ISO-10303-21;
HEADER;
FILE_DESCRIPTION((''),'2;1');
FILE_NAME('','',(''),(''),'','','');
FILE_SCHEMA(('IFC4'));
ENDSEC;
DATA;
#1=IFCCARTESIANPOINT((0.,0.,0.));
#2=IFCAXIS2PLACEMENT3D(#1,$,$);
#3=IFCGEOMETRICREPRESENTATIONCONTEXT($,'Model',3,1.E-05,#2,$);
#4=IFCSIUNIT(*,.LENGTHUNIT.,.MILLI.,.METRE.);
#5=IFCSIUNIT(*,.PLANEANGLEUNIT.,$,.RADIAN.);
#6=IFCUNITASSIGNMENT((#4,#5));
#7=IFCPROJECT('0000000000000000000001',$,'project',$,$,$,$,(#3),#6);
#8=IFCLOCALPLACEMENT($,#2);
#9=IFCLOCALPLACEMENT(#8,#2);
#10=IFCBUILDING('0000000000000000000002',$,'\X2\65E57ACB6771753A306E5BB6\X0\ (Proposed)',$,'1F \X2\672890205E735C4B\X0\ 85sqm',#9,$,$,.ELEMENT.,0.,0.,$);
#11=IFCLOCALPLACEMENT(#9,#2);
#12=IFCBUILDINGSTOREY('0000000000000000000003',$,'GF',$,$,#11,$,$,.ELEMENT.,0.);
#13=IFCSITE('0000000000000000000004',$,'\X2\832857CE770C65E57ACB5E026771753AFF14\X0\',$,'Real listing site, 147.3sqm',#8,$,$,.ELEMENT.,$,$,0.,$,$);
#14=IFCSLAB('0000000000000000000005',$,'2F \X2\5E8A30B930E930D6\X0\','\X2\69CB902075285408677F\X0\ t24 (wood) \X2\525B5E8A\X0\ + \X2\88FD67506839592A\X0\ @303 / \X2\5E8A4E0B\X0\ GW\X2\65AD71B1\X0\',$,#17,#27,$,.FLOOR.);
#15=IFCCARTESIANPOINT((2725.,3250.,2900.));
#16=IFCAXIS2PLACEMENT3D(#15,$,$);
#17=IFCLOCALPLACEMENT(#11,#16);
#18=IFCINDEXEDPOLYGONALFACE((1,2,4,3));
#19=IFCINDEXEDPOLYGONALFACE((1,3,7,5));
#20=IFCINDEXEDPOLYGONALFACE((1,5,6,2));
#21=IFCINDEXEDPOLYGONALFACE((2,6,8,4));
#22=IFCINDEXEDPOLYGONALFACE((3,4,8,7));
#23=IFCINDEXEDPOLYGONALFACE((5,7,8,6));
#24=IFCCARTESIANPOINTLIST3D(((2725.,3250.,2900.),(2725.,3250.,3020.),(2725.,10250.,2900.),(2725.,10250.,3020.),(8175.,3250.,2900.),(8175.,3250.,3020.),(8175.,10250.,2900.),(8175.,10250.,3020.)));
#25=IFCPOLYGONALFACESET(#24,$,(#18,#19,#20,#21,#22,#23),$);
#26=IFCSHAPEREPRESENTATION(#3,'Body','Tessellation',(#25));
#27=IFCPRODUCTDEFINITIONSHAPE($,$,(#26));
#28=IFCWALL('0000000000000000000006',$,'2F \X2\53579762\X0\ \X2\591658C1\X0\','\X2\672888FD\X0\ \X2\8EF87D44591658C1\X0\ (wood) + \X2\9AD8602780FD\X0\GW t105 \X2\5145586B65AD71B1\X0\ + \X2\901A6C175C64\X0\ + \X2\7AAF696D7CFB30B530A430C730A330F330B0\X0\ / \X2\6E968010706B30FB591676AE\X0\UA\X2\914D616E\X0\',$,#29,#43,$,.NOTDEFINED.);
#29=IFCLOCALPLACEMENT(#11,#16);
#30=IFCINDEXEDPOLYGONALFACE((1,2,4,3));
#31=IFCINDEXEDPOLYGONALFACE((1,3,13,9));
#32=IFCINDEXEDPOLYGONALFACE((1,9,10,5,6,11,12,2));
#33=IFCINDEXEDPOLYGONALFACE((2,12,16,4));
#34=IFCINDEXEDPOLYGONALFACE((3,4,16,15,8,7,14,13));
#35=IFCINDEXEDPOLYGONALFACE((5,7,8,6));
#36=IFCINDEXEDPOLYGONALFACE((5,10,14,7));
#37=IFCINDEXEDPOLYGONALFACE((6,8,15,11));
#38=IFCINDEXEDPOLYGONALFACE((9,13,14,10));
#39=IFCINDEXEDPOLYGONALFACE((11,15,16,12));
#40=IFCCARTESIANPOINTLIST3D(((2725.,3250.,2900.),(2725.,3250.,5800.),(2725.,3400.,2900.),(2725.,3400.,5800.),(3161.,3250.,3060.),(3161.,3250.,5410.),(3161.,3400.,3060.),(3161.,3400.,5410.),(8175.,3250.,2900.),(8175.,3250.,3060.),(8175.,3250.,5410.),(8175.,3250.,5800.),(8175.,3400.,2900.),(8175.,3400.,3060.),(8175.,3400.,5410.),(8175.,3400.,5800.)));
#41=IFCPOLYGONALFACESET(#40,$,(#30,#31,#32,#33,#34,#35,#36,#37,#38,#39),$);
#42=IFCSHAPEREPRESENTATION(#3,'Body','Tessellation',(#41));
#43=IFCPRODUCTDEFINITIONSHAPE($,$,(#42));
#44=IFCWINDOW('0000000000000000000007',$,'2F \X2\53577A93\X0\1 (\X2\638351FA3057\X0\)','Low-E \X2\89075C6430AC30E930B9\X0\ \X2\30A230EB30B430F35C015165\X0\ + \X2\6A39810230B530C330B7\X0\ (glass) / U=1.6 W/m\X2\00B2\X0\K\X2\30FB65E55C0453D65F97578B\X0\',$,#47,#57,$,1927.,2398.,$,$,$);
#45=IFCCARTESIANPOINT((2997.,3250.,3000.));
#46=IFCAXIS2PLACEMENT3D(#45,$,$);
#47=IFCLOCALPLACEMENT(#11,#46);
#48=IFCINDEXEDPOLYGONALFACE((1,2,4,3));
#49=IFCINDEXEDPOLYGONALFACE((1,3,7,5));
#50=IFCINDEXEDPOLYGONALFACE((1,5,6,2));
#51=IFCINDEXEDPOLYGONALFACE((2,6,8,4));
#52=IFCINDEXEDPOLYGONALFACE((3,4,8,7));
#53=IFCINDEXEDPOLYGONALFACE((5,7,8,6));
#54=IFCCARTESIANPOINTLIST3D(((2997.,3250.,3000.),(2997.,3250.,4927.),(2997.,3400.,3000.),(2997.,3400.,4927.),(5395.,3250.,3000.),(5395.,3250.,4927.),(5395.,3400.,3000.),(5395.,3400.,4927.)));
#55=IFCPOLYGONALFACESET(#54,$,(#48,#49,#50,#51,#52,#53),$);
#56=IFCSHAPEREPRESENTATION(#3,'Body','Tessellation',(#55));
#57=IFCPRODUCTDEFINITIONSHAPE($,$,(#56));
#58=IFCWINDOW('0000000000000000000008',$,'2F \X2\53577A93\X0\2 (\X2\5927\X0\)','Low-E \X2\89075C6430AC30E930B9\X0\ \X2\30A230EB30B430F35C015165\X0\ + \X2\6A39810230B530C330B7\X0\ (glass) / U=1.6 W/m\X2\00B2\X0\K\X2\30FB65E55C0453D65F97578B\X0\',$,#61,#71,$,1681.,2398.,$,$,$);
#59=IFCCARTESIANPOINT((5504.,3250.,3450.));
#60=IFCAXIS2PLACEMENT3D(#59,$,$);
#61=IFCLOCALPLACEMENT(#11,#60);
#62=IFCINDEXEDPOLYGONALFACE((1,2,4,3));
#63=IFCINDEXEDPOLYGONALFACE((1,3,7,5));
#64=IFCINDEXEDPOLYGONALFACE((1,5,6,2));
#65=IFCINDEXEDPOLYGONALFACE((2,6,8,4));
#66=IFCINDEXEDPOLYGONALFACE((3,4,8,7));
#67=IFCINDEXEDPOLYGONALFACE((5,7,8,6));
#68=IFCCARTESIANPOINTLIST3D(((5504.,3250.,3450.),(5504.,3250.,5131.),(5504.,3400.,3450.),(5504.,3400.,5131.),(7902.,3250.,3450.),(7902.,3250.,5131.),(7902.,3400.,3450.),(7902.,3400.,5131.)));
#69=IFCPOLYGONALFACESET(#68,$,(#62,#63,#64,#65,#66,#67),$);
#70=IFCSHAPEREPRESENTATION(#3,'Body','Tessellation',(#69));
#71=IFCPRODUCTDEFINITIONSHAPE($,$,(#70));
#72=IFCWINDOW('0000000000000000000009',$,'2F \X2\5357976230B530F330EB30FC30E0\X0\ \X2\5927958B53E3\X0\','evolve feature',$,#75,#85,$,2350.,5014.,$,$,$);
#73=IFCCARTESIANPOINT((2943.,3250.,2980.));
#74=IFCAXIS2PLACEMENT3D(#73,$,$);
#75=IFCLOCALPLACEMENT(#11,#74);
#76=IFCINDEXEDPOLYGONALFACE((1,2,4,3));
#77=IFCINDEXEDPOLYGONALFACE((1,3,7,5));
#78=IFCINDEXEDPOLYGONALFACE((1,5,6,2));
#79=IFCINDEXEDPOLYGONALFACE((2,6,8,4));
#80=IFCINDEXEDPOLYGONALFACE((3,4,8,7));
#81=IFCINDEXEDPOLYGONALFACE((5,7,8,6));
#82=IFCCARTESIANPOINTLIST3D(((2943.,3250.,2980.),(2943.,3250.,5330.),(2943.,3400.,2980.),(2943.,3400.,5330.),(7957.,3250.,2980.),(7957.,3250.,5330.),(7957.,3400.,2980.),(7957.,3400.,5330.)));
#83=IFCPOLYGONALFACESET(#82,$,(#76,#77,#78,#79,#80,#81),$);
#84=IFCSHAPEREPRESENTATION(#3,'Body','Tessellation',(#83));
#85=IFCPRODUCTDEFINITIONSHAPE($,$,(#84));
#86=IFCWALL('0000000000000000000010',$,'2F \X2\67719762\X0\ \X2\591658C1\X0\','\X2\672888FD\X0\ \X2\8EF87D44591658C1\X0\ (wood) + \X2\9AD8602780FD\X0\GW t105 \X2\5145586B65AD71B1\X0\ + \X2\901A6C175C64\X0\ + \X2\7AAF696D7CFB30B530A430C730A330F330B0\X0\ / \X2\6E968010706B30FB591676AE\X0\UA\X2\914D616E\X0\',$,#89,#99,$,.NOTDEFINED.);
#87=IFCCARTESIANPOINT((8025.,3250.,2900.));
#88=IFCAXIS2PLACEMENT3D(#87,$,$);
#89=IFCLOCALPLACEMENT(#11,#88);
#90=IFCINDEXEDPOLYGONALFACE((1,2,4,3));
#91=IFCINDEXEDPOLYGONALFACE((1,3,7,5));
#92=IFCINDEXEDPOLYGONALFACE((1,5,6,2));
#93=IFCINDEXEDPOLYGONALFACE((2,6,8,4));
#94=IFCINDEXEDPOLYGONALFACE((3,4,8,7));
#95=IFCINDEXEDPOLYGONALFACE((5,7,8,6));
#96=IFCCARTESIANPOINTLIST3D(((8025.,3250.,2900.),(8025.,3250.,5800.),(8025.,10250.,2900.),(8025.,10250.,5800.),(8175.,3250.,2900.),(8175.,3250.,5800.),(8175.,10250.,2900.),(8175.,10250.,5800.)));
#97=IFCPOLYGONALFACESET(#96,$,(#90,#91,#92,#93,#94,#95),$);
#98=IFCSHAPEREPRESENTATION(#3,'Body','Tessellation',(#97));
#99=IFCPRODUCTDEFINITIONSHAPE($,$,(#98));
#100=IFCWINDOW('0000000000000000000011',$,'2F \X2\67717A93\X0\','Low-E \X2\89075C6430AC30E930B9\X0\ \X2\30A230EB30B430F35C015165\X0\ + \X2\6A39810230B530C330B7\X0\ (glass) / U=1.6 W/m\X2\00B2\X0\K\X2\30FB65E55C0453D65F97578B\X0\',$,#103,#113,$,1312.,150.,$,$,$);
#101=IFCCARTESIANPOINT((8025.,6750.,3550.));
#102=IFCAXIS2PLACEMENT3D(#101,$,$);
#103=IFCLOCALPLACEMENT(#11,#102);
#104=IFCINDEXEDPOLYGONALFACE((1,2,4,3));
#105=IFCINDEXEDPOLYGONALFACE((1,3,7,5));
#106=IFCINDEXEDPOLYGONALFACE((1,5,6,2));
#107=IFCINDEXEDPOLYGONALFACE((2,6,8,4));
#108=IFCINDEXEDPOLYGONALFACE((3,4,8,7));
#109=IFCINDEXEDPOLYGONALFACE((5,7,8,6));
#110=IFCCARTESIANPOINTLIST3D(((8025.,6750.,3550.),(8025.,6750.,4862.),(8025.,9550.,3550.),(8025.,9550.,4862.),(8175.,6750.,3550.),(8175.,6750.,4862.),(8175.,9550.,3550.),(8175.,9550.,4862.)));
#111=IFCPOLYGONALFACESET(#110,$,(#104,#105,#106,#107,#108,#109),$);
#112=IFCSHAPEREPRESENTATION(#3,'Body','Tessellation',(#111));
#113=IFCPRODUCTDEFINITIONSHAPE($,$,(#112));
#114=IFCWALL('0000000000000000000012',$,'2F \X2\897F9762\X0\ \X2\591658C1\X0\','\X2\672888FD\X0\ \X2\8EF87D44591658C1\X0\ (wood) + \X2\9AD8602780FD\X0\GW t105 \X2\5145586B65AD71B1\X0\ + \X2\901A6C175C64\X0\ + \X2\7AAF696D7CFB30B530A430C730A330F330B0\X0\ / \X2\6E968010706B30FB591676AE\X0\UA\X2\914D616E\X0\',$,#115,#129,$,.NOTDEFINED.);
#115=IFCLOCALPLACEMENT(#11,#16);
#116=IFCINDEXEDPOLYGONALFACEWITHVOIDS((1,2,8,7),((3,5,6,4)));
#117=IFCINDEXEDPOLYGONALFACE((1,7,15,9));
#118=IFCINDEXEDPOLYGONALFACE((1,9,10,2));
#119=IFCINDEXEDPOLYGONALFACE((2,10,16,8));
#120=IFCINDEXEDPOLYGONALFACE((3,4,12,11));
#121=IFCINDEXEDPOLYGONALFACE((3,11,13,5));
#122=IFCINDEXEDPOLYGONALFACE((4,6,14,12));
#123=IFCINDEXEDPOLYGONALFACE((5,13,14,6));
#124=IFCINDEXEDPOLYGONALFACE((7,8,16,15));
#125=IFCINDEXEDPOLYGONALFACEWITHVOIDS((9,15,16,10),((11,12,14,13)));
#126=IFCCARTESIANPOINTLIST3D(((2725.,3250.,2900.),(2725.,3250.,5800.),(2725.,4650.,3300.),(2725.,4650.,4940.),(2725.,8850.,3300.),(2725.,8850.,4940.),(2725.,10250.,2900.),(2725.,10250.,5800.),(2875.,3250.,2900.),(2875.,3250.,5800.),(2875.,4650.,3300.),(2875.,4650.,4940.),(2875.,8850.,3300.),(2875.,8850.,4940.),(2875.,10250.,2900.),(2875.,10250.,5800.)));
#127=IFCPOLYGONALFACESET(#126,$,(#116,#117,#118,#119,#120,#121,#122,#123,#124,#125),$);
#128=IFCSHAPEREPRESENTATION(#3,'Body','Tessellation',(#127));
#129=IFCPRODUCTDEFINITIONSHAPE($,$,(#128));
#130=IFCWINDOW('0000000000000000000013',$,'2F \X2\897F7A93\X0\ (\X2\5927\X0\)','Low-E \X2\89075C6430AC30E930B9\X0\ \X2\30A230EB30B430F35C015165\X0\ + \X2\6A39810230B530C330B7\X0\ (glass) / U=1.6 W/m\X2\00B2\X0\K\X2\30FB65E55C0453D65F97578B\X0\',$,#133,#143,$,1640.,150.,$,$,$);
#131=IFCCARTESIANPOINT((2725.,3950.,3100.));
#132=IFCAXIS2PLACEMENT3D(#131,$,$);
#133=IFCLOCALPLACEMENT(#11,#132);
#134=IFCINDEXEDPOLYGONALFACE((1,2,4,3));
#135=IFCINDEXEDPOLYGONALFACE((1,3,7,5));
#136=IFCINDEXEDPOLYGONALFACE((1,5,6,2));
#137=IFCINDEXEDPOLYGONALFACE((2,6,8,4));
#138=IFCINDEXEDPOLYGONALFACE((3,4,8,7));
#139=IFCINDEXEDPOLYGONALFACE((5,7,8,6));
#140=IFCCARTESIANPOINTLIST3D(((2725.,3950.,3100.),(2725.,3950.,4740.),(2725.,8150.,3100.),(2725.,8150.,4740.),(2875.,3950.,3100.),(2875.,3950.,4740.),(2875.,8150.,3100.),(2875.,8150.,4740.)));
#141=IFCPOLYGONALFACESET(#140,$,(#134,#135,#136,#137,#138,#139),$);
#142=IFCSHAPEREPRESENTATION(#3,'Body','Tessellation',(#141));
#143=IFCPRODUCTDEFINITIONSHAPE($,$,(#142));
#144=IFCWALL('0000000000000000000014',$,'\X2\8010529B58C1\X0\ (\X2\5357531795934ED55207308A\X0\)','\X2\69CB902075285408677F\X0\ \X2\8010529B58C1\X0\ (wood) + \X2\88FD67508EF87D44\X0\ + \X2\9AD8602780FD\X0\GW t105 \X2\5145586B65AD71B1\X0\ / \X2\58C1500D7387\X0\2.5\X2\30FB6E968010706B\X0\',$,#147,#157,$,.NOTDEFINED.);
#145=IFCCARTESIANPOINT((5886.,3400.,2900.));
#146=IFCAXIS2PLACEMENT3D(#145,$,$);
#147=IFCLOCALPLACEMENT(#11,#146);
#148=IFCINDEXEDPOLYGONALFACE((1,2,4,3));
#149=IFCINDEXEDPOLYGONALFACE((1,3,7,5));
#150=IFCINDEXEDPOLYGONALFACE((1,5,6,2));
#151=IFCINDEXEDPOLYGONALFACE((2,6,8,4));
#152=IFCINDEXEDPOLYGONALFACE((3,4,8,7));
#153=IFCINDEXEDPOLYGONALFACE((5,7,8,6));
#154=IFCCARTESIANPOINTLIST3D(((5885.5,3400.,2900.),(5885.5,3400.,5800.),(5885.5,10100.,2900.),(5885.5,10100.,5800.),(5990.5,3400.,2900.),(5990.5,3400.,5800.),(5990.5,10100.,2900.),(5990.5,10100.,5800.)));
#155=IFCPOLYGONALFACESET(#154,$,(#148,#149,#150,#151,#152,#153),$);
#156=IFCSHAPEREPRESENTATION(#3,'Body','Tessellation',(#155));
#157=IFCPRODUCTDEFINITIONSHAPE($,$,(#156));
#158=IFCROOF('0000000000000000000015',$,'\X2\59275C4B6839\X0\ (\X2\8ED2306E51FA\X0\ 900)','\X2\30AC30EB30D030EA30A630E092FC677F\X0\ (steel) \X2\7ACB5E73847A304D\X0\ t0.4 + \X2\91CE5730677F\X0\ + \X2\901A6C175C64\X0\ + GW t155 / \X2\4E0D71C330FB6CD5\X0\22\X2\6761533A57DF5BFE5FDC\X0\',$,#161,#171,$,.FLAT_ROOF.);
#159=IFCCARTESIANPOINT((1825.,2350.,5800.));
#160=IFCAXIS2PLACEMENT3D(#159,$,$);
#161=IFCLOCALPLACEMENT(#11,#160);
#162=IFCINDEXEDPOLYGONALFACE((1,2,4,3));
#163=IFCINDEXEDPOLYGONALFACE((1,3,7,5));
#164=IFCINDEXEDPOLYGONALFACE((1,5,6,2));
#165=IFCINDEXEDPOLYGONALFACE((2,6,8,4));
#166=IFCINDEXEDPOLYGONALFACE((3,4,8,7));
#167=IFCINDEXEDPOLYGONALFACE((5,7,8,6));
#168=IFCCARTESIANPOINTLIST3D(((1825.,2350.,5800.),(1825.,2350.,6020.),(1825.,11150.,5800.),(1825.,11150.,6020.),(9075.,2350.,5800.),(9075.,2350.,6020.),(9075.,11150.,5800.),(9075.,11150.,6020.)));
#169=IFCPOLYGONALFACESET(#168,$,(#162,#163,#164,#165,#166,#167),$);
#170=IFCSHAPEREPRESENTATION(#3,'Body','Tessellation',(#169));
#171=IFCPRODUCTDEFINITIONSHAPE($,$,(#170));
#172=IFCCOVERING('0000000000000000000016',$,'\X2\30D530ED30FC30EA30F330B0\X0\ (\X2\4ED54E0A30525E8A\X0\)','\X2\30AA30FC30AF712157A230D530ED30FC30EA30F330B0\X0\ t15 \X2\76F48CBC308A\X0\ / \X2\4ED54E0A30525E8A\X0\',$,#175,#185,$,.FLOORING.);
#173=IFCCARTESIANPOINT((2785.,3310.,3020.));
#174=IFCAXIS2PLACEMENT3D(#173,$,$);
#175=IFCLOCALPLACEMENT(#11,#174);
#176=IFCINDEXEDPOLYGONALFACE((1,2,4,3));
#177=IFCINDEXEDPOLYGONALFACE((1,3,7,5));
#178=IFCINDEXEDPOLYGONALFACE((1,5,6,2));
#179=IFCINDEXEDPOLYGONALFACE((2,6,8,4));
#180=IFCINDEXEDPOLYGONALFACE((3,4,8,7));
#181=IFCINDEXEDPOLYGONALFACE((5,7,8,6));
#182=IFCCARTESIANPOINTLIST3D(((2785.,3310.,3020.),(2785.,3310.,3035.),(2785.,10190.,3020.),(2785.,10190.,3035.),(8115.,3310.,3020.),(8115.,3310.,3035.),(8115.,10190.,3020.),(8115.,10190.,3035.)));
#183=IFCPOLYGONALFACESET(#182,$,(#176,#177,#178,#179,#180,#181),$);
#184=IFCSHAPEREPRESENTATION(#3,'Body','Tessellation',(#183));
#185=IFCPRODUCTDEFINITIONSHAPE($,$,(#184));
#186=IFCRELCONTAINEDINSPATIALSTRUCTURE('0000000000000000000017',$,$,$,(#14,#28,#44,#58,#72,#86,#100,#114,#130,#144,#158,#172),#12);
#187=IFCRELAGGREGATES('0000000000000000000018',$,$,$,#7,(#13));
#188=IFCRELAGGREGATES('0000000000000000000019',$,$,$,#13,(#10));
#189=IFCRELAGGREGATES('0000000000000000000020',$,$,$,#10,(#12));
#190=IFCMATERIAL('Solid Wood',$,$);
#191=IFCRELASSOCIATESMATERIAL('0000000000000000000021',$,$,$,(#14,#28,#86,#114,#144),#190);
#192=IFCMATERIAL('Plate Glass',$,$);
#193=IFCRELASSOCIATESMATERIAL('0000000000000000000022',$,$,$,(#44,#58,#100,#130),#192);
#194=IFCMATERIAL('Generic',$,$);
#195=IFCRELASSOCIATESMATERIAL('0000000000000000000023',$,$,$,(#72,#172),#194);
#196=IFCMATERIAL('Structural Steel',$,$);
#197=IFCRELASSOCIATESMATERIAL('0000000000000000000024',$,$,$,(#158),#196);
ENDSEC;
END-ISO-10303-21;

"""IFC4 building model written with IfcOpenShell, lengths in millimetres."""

from ifc_helpers import new_model, si_unit, frame, frame_2d, origin, place, context, project, spatial, rectangle, extrude, material, element, fill, save


model = new_model("IFC4")

# Units and contexts
model_context = context("Model", 3, precision=1e-05, world=origin())
ifc_project = project(units=[si_unit("LENGTHUNIT", "METRE", prefix="MILLI"), si_unit("PLANEANGLEUNIT", "RADIAN")], contexts=[model_context])

# Site, building, storey
site_placement = place(None, origin())
site = spatial("IfcSite", under=ifc_project, at=site_placement, Name="茨城県日立市東町４", ObjectType="Real listing site, 147.3sqm", CompositionType="ELEMENT", RefElevation=0.0)
building_placement = place(site_placement, origin())
building = spatial("IfcBuilding", under=site, at=building_placement, Name="日立東町の家 (Proposed)", ObjectType="1F 木造平屋 85sqm", CompositionType="ELEMENT", ElevationOfRefHeight=0.0, ElevationOfTerrain=0.0)
storey_placement = place(building_placement, origin())
storey = spatial("IfcBuildingStorey", under=building, at=storey_placement, Name="GF", CompositionType="ELEMENT", Elevation=0.0)

# Slab
ifc_material_1 = material(Name="Solid Wood")
slab_placement = place(storey_placement, frame((2725.0, 3250.0, 2900.0)))
element("IfcSlab", 1, at=slab_placement, inside=storey, material=ifc_material_1, Name="2F 床スラブ", Description="構造用合板 t24 (wood) 剛床 + 製材根太 @303 / 床下 GW断熱", PredefinedType="FLOOR", context=model_context, shape_type="SweptSolid", body=[
    extrude(rectangle(XDim=5450.0, YDim=7000.0, at=frame_2d((2725.0, 3500.0))), frame((2725.0, 3250.0, 2900.0)), (0.0, 0.0, 1.0), 120.0),
])

# Wall, openings, windows
wall_1_placement = place(storey_placement, frame((2725.0, 3250.0, 2900.0)))
wall_1 = element("IfcWall", 2, at=wall_1_placement, inside=storey, material=ifc_material_1, Name="2F 南面 外壁", Description="木製 軸組外壁 (wood) + 高性能GW t105 充填断熱 + 通気層 + 窯業系サイディング / 準耐火・外皮UA配慮", PredefinedType="NOTDEFINED", context=model_context, shape_type="SweptSolid", body=[
    extrude(rectangle(XDim=5450.0, YDim=150.0, at=frame_2d((2725.0, 75.0))), frame((2725.0, 3250.0, 2900.0)), (0.0, 0.0, 1.0), 2900.0),
])
opening_1_placement = place(storey_placement, frame((2997.0, 3250.0, 3000.0)))
opening_1 = element("IfcOpeningElement", 3, at=opening_1_placement, cuts=wall_1, PredefinedType="NOTDEFINED", context=model_context, shape_type="SweptSolid", body=[
    extrude(rectangle(XDim=2398.0, YDim=150.0, at=frame_2d((1199.0, 75.0))), frame((2997.0, 3250.0, 3000.0)), (0.0, 0.0, 1.0), 1927.0),
])
opening_2_placement = place(storey_placement, frame((5504.0, 3250.0, 3450.0)))
opening_2 = element("IfcOpeningElement", 4, at=opening_2_placement, cuts=wall_1, PredefinedType="NOTDEFINED", context=model_context, shape_type="SweptSolid", body=[
    extrude(rectangle(XDim=2398.0, YDim=150.0, at=frame_2d((1199.0, 75.0))), frame((5504.0, 3250.0, 3450.0)), (0.0, 0.0, 1.0), 1681.0),
])
opening_3_placement = place(storey_placement, frame((2943.0, 3250.0, 2980.0)))
opening_3 = element("IfcOpeningElement", 5, at=opening_3_placement, cuts=wall_1, PredefinedType="NOTDEFINED", context=model_context, shape_type="SweptSolid", body=[
    extrude(rectangle(XDim=5014.0, YDim=150.0, at=frame_2d((2507.0, 75.0))), frame((2943.0, 3250.0, 2980.0)), (0.0, 0.0, 1.0), 2350.0),
])
ifc_material_2 = material(Name="Plate Glass")
window_1_placement = place(storey_placement, frame((2997.0, 3250.0, 3000.0)))
window_1 = element("IfcWindow", 6, at=window_1_placement, inside=storey, material=ifc_material_2, Name="2F 南窓1 (掃出し)", Description="Low-E 複層ガラス アルゴン封入 + 樹脂サッシ (glass) / U=1.6 W/m²K・日射取得型", OverallHeight=1927.0, OverallWidth=2398.0, context=model_context, shape_type="SweptSolid", body=[
    extrude(rectangle(XDim=2398.0, YDim=150.0, at=frame_2d((1199.0, 75.0))), frame((2997.0, 3250.0, 3000.0)), (0.0, 0.0, 1.0), 1927.0),
])
fill(opening_1, window_1)
window_2_placement = place(storey_placement, frame((5504.0, 3250.0, 3450.0)))
window_2 = element("IfcWindow", 7, at=window_2_placement, inside=storey, material=ifc_material_2, Name="2F 南窓2 (大)", Description="Low-E 複層ガラス アルゴン封入 + 樹脂サッシ (glass) / U=1.6 W/m²K・日射取得型", OverallHeight=1681.0, OverallWidth=2398.0, context=model_context, shape_type="SweptSolid", body=[
    extrude(rectangle(XDim=2398.0, YDim=150.0, at=frame_2d((1199.0, 75.0))), frame((5504.0, 3250.0, 3450.0)), (0.0, 0.0, 1.0), 1681.0),
])
fill(opening_2, window_2)
ifc_material_3 = material(Name="Generic")
window_3_placement = place(storey_placement, frame((2943.0, 3250.0, 2980.0)))
window_3 = element("IfcWindow", 8, at=window_3_placement, inside=storey, material=ifc_material_3, Name="2F 南面サンルーム 大開口", Description="evolve feature", OverallHeight=2350.0, OverallWidth=5014.0, context=model_context, shape_type="SweptSolid", body=[
    extrude(rectangle(XDim=5014.0, YDim=150.0, at=frame_2d((2507.0, 75.0))), frame((2943.0, 3250.0, 2980.0)), (0.0, 0.0, 1.0), 2350.0),
])
fill(opening_3, window_3)

# Walls, openings, windows
wall_2_placement = place(storey_placement, frame((8025.0, 3250.0, 2900.0)))
wall_2 = element("IfcWall", 9, at=wall_2_placement, inside=storey, material=ifc_material_1, Name="2F 東面 外壁", Description="木製 軸組外壁 (wood) + 高性能GW t105 充填断熱 + 通気層 + 窯業系サイディング / 準耐火・外皮UA配慮", PredefinedType="NOTDEFINED", context=model_context, shape_type="SweptSolid", body=[
    extrude(rectangle(XDim=150.0, YDim=7000.0, at=frame_2d((75.0, 3500.0))), frame((8025.0, 3250.0, 2900.0)), (0.0, 0.0, 1.0), 2900.0),
])
opening_4_placement = place(storey_placement, frame((8025.0, 6750.0, 3550.0)))
opening_4 = element("IfcOpeningElement", 10, at=opening_4_placement, cuts=wall_2, PredefinedType="NOTDEFINED", context=model_context, shape_type="SweptSolid", body=[
    extrude(rectangle(XDim=150.0, YDim=2800.0, at=frame_2d((75.0, 1400.0))), frame((8025.0, 6750.0, 3550.0)), (0.0, 0.0, 1.0), 1312.0),
])
window_4_placement = place(storey_placement, frame((8025.0, 6750.0, 3550.0)))
window_4 = element("IfcWindow", 11, at=window_4_placement, inside=storey, material=ifc_material_2, Name="2F 東窓", Description="Low-E 複層ガラス アルゴン封入 + 樹脂サッシ (glass) / U=1.6 W/m²K・日射取得型", OverallHeight=1312.0, OverallWidth=150.0, context=model_context, shape_type="SweptSolid", body=[
    extrude(rectangle(XDim=150.0, YDim=2800.0, at=frame_2d((75.0, 1400.0))), frame((8025.0, 6750.0, 3550.0)), (0.0, 0.0, 1.0), 1312.0),
])
fill(opening_4, window_4)
wall_3_placement = place(storey_placement, frame((2725.0, 3250.0, 2900.0)))
wall_3 = element("IfcWall", 12, at=wall_3_placement, inside=storey, material=ifc_material_1, Name="2F 西面 外壁", Description="木製 軸組外壁 (wood) + 高性能GW t105 充填断熱 + 通気層 + 窯業系サイディング / 準耐火・外皮UA配慮", PredefinedType="NOTDEFINED", context=model_context, shape_type="SweptSolid", body=[
    extrude(rectangle(XDim=150.0, YDim=7000.0, at=frame_2d((75.0, 3500.0))), frame((2725.0, 3250.0, 2900.0)), (0.0, 0.0, 1.0), 2900.0),
])
opening_5_placement = place(storey_placement, frame((2725.0, 3950.0, 3100.0)))
opening_5 = element("IfcOpeningElement", 13, at=opening_5_placement, cuts=wall_3, PredefinedType="NOTDEFINED", context=model_context, shape_type="SweptSolid", body=[
    extrude(rectangle(XDim=150.0, YDim=4200.0, at=frame_2d((75.0, 2100.0))), frame((2725.0, 3950.0, 3100.0)), (0.0, 0.0, 1.0), 1640.0),
])
window_5_placement = place(storey_placement, frame((2725.0, 3950.0, 3100.0)))
window_5 = element("IfcWindow", 14, at=window_5_placement, inside=storey, material=ifc_material_2, Name="2F 西窓 (大)", Description="Low-E 複層ガラス アルゴン封入 + 樹脂サッシ (glass) / U=1.6 W/m²K・日射取得型", OverallHeight=1640.0, OverallWidth=150.0, context=model_context, shape_type="SweptSolid", body=[
    extrude(rectangle(XDim=150.0, YDim=4200.0, at=frame_2d((75.0, 2100.0))), frame((2725.0, 3950.0, 3100.0)), (0.0, 0.0, 1.0), 1640.0),
])
fill(opening_5, window_5)

# Wall
wall_4_placement = place(storey_placement, frame((5886.0, 3400.0, 2900.0)))
element("IfcWall", 15, at=wall_4_placement, inside=storey, material=ifc_material_1, Name="耐力壁 (南北間仕切り)", Description="構造用合板 耐力壁 (wood) + 製材軸組 + 高性能GW t105 充填断熱 / 壁倍率2.5・準耐火", PredefinedType="NOTDEFINED", context=model_context, shape_type="SweptSolid", body=[
    extrude(rectangle(XDim=105.0, YDim=6700.0, at=frame_2d((52.0, 3350.0))), frame((5886.0, 3400.0, 2900.0)), (0.0, 0.0, 1.0), 2900.0),
])

# Roof
ifc_material_4 = material(Name="Structural Steel")
roof_placement = place(storey_placement, frame((1825.0, 2350.0, 5800.0)))
element("IfcRoof", 16, at=roof_placement, inside=storey, material=ifc_material_4, Name="大屋根 (軒の出 900)", Description="ガルバリウム鋼板 (steel) 立平葺き t0.4 + 野地板 + 通気層 + GW t155 / 不燃・法22条区域対応", PredefinedType="FLAT_ROOF", context=model_context, shape_type="SweptSolid", body=[
    extrude(rectangle(XDim=7250.0, YDim=8800.0, at=frame_2d((3625.0, 4400.0))), frame((1825.0, 2350.0, 5800.0)), (0.0, 0.0, 1.0), 220.0),
])

# Covering
covering_placement = place(storey_placement, frame((2785.0, 3310.0, 3020.0)))
element("IfcCovering", 17, at=covering_placement, inside=storey, material=ifc_material_3, Name="フローリング (仕上げ床)", Description="オーク無垢フローリング t15 直貼り / 仕上げ床", PredefinedType="FLOORING", context=model_context, shape_type="SweptSolid", body=[
    extrude(rectangle(XDim=5330.0, YDim=6880.0, at=frame_2d((2665.0, 3440.0))), frame((2785.0, 3310.0, 3020.0)), (0.0, 0.0, 1.0), 15.0),
])

save(model, "model.ifc")
